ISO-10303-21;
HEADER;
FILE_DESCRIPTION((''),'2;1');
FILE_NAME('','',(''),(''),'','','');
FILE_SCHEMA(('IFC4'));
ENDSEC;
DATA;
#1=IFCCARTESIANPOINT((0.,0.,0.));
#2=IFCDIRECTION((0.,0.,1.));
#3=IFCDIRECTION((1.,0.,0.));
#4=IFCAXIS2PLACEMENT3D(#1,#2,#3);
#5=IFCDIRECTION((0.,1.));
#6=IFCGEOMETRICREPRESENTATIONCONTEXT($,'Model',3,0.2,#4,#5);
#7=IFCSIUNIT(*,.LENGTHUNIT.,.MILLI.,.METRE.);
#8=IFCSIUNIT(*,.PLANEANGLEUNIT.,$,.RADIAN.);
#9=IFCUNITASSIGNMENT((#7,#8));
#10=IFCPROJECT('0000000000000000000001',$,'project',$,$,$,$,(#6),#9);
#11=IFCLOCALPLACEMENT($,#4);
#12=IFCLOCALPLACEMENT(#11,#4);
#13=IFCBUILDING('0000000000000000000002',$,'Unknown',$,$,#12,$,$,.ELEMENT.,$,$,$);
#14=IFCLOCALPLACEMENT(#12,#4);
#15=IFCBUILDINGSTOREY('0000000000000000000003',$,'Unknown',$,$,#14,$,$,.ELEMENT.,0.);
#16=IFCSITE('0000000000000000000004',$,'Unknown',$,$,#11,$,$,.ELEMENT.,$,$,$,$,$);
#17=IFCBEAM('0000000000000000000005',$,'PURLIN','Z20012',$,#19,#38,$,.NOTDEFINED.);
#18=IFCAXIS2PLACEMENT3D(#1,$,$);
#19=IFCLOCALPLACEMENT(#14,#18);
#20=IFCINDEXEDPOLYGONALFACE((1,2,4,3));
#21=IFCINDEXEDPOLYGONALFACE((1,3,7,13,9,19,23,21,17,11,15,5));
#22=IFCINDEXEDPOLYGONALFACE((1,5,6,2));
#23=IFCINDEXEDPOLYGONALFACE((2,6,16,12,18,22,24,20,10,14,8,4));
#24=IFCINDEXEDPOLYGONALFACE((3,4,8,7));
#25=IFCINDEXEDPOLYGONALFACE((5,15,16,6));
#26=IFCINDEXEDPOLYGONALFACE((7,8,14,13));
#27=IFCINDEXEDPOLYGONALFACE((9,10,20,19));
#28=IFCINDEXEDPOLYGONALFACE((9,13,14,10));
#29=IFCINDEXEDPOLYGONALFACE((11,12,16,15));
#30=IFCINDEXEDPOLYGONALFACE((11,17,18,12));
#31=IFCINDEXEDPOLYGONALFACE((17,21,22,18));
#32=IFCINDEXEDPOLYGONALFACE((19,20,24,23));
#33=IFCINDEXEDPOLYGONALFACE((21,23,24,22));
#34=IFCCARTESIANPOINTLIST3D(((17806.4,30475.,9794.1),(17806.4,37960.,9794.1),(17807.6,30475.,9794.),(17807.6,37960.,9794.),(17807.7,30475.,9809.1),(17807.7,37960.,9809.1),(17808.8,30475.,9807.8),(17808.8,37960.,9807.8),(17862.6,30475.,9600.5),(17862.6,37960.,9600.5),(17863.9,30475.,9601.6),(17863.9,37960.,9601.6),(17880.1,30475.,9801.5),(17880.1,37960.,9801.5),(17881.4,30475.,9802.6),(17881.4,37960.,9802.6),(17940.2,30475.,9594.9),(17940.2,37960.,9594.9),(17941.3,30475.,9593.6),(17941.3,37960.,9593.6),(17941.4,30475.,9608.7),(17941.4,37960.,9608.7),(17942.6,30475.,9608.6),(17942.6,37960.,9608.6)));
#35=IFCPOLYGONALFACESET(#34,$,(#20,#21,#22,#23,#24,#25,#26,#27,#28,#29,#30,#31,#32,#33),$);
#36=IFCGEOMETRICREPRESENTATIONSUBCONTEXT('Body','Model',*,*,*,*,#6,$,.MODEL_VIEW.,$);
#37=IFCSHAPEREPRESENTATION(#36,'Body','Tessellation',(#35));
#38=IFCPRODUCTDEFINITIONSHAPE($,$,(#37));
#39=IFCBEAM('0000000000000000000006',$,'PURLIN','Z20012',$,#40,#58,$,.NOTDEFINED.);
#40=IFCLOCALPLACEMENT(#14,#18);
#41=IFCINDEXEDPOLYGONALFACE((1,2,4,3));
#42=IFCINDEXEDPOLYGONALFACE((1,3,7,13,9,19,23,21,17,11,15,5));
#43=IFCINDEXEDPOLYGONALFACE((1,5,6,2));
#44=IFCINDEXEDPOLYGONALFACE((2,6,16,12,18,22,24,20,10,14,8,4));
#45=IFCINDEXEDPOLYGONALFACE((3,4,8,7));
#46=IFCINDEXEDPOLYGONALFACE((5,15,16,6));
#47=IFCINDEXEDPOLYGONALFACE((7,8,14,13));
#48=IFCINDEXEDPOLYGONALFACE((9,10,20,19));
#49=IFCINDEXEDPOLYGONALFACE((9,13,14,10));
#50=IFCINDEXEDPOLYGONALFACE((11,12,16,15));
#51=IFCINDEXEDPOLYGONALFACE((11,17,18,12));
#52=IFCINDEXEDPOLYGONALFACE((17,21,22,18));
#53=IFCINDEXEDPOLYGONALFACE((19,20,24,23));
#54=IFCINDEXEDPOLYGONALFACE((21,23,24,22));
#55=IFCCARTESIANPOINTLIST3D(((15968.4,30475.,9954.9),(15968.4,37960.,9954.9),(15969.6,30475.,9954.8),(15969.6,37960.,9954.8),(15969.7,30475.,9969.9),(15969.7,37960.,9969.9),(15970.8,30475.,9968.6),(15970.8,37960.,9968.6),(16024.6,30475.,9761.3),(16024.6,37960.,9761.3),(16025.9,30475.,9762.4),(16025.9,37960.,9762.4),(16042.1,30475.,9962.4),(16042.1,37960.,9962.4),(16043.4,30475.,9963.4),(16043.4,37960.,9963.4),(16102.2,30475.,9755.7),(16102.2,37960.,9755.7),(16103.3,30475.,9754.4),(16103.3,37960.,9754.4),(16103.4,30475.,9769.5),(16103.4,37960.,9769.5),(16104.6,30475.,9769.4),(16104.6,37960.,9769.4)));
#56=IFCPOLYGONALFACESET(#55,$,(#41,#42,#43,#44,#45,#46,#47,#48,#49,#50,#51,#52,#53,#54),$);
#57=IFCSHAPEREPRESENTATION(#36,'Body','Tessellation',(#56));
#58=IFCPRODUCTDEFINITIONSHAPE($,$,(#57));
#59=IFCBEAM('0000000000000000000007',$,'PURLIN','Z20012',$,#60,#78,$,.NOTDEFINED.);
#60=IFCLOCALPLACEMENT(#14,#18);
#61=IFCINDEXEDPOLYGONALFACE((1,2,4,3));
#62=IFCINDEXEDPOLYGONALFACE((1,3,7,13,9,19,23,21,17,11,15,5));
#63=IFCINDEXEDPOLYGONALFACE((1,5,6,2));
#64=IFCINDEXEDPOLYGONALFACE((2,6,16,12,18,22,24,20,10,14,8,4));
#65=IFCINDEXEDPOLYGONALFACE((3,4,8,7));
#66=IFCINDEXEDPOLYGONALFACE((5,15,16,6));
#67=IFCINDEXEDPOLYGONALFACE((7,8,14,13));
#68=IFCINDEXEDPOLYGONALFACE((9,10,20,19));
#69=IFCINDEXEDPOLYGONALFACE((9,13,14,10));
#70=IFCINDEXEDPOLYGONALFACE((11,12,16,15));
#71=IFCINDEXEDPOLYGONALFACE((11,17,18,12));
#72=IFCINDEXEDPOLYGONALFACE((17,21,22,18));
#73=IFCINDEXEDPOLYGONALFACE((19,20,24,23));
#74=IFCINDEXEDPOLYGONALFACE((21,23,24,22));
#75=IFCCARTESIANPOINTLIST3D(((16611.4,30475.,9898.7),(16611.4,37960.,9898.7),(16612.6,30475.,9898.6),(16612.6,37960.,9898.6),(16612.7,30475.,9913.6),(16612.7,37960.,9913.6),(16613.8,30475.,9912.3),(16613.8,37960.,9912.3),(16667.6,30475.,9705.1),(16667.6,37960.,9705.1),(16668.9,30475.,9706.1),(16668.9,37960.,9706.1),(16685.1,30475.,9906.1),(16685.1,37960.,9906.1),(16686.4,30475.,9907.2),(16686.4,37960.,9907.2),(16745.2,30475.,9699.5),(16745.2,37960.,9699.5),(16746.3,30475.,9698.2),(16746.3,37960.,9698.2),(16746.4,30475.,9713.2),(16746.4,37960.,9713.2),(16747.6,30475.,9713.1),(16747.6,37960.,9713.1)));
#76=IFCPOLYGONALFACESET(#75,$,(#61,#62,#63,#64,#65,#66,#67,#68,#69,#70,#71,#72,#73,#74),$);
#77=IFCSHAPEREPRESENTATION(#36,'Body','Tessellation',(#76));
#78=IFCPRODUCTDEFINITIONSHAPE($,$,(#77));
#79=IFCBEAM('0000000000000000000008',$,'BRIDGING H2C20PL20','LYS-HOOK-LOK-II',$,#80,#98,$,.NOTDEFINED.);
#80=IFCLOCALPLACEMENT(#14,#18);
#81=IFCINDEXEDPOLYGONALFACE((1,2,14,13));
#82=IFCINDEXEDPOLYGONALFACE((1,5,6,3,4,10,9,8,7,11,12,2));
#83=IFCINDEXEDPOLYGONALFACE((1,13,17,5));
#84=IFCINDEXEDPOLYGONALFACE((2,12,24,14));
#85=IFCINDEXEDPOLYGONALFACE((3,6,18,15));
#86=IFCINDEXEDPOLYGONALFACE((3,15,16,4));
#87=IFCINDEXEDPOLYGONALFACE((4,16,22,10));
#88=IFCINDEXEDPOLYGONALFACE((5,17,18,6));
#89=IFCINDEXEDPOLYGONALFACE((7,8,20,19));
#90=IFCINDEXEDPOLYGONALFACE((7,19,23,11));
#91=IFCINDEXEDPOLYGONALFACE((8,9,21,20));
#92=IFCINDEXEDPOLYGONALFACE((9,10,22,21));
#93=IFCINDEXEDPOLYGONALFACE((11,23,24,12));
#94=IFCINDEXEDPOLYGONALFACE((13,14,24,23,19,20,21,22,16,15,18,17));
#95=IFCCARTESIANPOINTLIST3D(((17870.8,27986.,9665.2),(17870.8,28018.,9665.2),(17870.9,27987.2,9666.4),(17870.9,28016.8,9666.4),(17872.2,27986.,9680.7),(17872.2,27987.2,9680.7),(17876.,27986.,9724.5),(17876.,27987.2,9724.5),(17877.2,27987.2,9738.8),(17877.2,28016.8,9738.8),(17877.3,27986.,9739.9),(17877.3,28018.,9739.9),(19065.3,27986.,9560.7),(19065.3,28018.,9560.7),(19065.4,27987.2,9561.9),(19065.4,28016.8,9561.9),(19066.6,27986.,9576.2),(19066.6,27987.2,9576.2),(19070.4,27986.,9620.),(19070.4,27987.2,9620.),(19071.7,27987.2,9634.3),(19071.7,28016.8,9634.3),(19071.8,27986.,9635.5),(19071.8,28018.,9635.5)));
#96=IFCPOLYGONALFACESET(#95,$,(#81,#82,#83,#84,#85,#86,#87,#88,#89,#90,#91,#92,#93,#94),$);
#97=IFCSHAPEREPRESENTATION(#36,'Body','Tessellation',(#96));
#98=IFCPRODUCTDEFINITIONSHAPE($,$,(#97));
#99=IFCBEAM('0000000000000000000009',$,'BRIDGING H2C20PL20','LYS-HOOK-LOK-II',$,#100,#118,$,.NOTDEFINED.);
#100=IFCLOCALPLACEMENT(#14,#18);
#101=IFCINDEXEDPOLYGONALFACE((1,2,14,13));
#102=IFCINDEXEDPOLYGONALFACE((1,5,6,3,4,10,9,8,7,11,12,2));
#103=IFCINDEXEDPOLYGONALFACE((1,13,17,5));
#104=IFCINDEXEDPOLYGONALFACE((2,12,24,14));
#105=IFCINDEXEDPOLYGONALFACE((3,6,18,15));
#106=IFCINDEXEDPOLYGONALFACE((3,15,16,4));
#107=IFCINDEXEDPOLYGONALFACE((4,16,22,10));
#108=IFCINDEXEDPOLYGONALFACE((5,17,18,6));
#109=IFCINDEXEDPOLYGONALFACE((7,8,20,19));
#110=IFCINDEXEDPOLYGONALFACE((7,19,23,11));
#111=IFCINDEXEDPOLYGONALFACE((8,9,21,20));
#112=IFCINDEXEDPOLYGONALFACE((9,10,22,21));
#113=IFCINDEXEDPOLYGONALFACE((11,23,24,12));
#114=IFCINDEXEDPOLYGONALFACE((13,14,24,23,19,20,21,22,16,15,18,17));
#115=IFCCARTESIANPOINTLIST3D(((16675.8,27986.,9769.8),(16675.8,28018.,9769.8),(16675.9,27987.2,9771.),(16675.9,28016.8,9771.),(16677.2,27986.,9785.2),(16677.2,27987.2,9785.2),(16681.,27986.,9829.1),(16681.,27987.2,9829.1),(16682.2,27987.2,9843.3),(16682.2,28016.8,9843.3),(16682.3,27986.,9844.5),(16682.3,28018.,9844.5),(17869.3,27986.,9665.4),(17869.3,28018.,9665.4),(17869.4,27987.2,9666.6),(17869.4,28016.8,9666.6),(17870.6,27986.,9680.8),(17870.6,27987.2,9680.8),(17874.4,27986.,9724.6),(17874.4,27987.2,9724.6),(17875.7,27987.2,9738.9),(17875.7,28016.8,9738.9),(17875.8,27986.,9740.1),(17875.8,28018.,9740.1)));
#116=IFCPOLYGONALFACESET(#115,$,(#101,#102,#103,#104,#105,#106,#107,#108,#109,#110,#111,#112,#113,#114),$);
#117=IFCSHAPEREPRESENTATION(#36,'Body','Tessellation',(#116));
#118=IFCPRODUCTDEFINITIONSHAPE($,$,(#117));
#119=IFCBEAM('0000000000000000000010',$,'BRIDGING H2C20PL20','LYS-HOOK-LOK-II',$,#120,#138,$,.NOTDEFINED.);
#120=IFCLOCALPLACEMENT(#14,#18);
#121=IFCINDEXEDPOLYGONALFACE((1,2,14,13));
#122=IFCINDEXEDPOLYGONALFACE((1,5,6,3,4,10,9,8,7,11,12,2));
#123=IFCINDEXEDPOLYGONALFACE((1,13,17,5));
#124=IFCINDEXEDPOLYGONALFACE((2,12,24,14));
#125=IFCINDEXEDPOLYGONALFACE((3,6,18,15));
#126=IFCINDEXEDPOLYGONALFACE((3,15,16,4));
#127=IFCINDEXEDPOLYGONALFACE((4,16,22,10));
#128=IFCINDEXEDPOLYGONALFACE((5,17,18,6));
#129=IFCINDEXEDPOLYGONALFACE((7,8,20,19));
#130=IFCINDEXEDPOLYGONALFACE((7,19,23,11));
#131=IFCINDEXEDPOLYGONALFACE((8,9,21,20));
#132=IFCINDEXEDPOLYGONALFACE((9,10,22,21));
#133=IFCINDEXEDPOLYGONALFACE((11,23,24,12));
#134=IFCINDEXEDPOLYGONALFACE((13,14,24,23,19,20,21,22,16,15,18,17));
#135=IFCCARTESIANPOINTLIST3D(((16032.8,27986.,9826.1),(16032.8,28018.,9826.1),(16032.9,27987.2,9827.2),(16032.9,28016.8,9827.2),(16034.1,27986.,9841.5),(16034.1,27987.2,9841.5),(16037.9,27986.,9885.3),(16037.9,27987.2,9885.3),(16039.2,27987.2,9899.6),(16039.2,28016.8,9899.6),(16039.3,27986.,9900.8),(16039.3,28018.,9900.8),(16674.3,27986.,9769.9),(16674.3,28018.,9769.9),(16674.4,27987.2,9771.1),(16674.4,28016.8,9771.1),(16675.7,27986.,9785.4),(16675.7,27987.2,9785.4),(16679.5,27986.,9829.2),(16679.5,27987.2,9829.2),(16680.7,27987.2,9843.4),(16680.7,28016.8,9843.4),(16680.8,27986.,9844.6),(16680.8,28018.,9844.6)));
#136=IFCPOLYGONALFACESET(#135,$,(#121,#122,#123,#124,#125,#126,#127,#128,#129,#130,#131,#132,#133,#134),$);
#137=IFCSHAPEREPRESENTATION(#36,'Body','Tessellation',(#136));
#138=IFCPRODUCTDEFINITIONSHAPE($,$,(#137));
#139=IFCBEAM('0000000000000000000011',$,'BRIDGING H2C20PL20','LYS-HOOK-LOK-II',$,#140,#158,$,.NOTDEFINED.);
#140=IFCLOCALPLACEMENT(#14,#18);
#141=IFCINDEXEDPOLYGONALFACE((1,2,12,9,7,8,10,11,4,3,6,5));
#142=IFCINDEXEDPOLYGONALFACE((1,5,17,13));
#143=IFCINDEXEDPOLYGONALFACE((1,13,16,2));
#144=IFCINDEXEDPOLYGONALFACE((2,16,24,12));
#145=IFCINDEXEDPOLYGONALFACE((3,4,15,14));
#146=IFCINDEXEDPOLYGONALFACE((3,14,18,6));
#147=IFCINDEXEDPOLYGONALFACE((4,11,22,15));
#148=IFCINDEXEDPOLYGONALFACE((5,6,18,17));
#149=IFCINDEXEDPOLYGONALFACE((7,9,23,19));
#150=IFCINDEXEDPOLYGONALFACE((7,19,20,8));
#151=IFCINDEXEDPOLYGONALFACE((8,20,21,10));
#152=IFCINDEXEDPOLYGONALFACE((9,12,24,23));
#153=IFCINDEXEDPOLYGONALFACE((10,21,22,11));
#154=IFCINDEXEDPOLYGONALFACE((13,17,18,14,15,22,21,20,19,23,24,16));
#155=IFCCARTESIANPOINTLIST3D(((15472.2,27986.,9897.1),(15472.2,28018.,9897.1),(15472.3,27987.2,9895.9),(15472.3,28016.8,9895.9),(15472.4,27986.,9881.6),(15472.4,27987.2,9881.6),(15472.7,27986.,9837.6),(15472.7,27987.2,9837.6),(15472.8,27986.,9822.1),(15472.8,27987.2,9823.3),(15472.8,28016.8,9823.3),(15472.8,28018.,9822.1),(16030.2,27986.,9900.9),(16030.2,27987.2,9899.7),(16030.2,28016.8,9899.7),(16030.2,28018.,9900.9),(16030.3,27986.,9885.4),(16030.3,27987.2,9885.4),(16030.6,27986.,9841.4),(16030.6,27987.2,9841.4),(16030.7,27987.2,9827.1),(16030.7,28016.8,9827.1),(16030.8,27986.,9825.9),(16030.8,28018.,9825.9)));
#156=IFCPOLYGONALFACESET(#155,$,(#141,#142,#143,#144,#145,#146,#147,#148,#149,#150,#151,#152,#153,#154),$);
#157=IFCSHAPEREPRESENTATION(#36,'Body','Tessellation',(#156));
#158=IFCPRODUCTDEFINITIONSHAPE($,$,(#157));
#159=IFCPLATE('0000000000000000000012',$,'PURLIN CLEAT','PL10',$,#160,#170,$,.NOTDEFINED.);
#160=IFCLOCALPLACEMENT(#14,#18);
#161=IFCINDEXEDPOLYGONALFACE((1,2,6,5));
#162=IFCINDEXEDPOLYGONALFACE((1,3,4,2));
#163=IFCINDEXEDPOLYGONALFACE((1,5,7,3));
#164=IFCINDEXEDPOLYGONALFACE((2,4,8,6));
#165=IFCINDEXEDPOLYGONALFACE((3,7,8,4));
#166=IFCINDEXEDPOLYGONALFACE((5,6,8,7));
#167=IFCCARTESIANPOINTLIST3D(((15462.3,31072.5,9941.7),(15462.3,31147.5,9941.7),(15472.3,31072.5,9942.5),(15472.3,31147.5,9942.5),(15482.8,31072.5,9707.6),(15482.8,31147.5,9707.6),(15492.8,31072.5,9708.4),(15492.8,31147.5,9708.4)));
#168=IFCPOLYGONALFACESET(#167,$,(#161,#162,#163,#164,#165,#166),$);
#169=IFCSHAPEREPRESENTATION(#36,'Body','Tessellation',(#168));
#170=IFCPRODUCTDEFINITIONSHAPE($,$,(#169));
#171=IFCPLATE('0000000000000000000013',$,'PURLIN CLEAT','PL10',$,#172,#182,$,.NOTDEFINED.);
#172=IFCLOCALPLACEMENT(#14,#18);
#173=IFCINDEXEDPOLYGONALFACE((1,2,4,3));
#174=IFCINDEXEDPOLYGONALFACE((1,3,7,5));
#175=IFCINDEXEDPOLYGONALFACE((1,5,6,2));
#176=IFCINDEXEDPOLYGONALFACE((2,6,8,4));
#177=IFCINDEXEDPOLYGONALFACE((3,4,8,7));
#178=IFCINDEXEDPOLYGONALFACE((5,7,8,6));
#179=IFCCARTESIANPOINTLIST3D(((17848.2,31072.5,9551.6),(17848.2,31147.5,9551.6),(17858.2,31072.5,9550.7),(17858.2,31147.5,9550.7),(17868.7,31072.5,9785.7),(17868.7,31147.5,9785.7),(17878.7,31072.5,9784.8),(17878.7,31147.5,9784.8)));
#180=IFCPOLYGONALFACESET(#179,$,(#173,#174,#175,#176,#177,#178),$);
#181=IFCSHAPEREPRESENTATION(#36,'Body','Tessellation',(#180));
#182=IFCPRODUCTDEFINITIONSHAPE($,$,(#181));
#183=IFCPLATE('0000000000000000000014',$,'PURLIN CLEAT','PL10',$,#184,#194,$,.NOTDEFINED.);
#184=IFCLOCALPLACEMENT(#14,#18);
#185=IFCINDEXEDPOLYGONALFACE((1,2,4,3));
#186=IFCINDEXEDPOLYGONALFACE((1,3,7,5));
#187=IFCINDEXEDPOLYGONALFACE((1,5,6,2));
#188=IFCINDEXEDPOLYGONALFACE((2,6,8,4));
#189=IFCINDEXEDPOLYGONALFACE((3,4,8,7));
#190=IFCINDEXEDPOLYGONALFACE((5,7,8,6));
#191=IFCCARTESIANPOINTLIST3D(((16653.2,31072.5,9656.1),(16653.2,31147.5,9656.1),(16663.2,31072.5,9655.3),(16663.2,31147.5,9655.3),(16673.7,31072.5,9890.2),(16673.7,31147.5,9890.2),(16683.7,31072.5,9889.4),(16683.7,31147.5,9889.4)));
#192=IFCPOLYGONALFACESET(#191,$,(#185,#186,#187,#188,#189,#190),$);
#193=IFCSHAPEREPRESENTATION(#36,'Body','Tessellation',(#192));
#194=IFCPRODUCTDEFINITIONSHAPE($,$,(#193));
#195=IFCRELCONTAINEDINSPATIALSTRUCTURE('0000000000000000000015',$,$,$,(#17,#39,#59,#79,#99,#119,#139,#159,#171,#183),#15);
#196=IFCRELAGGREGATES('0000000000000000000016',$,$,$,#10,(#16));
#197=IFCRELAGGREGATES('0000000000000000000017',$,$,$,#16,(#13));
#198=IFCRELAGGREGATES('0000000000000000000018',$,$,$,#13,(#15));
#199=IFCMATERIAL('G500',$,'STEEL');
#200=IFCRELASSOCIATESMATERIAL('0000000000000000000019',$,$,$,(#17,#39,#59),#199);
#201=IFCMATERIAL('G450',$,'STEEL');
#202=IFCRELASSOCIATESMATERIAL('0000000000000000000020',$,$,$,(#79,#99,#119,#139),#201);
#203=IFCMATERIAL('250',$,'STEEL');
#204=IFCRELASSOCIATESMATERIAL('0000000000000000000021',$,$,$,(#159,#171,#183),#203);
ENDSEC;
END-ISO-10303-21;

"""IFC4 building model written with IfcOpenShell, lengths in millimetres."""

from ifc_helpers import new_model, si_unit, direction, frame, origin_with_axes, place, context, subcontext, project, spatial, line, indexed_curve, outline, extrude, material, element, save


model = new_model("IFC4")

# Units and contexts
model_context = context("Model", 3, precision=0.2, world=origin_with_axes(), true_north=direction((0.0, 1.0)))
body_context = subcontext(model_context, "Body", "Model", "MODEL_VIEW")
ifc_project = project(units=[si_unit("LENGTHUNIT", "METRE", prefix="MILLI"), si_unit("PLANEANGLEUNIT", "RADIAN")], contexts=[model_context])

# Site, building, storey
site_placement = place(None, origin_with_axes())
site = spatial("IfcSite", under=ifc_project, at=site_placement, Name="Unknown", CompositionType="ELEMENT")
building_placement = place(site_placement, origin_with_axes())
building = spatial("IfcBuilding", under=site, at=building_placement, Name="Unknown", CompositionType="ELEMENT")
storey_placement = place(building_placement, origin_with_axes())
storey = spatial("IfcBuildingStorey", under=building, at=storey_placement, Name="Unknown", CompositionType="ELEMENT", Elevation=0.0)

# Beams
ifc_material_1 = material(Name="G500", Category="STEEL")
for number, where, z_axis, x_axis, name in (
    (1, (17872.0, 30475.0, 9701.6), (-0.996195, 0.0, 0.087156), (0.0, 1.0, 0.0), "PURLIN"),
    (2, (16034.0, 30475.0, 9862.4), (-0.996195, 0.0, 0.087156), (0.0, 1.0, 0.0), "PURLIN"),
    (3, (16677.0, 30475.0, 9806.1), (-0.996195, 0.0, 0.087156), (0.0, 1.0, 0.0), "PURLIN"),
):
    element("IfcBeam", number, at=place(storey_placement, frame(where, z_axis=z_axis, x_axis=x_axis)), inside=storey, material=ifc_material_1, Name=name, Description="Z20012", PredefinedType="NOTDEFINED", context=body_context, shape_type="SolidModel", body=[
        extrude(outline(indexed_curve([(73.4, -101.5), (73.4, -86.5), (72.2, -86.5), (72.2, -100.3), (0.6, -100.3), (0.6, 101.5), (-78.4, 101.5), (-78.4, 86.5), (-77.2, 86.5), (-77.2, 100.3), (-0.6, 100.3), (-0.6, -101.5)], segments=[line(1, 2, 3, 4, 5, 6, 7, 8, 9, 10, 11, 12, 1)])), frame((0.0, 0.0, 0.0), z_axis=(-1.0, 0.0, 0.0), x_axis=(0.0, 0.0, 1.0)), (0.0, 0.0, -1.0), 7485.0),
    ])
ifc_material_2 = material(Name="G450", Category="STEEL")
beam_1_placement = place(storey_placement, frame((17874.1, 28002.0, 9702.6), z_axis=(0.0, -1.0, 0.0), x_axis=(0.996195, 0.0, -0.08715)))
element("IfcBeam", 4, at=beam_1_placement, inside=storey, material=ifc_material_2, Name="BRIDGING H2C20PL20", Description="LYS-HOOK-LOK-II", PredefinedType="NOTDEFINED", context=body_context, shape_type="SolidModel", body=[
    extrude(outline(indexed_curve([(16.0, -37.5), (16.0, -22.0), (14.8, -22.0), (14.8, -36.3), (-14.8, -36.3), (-14.8, 36.3), (14.8, 36.3), (14.8, 22.0), (16.0, 22.0), (16.0, 37.5), (-16.0, 37.5), (-16.0, -37.5)], segments=[line(1, 2, 3, 4, 5, 6, 7, 8, 9, 10, 11, 12, 1)])), frame((0.0, 0.0, 0.0), z_axis=(-1.0, 0.0, 0.0), x_axis=(0.0, 0.0, 1.0)), (0.0, 0.0, -1.0), 1199.0),
])
beam_2_placement = place(storey_placement, frame((16679.1, 28002.0, 9807.1), z_axis=(0.0, -1.0, 0.0), x_axis=(0.996195, 0.0, -0.087157)))
element("IfcBeam", 5, at=beam_2_placement, inside=storey, material=ifc_material_2, Name="BRIDGING H2C20PL20", Description="LYS-HOOK-LOK-II", PredefinedType="NOTDEFINED", context=body_context, shape_type="SolidModel", body=[
    extrude(outline(indexed_curve([(16.0, -37.5), (16.0, -22.0), (14.8, -22.0), (14.8, -36.3), (-14.8, -36.3), (-14.8, 36.3), (14.8, 36.3), (14.8, 22.0), (16.0, 22.0), (16.0, 37.5), (-16.0, 37.5), (-16.0, -37.5)], segments=[line(1, 2, 3, 4, 5, 6, 7, 8, 9, 10, 11, 12, 1)])), frame((0.0, 0.0, 0.0), z_axis=(-1.0, 0.0, 0.0), x_axis=(0.0, 0.0, 1.0)), (0.0, 0.0, -1.0), 1198.0),
])
beam_3_placement = place(storey_placement, frame((16036.0, 28002.0, 9863.4), z_axis=(0.0, -1.0, 0.0), x_axis=(0.996194, 0.0, -0.087163)))
element("IfcBeam", 6, at=beam_3_placement, inside=storey, material=ifc_material_2, Name="BRIDGING H2C20PL20", Description="LYS-HOOK-LOK-II", PredefinedType="NOTDEFINED", context=body_context, shape_type="SolidModel", body=[
    extrude(outline(indexed_curve([(16.0, -37.5), (16.0, -22.0), (14.8, -22.0), (14.8, -36.3), (-14.8, -36.3), (-14.8, 36.3), (14.8, 36.3), (14.8, 22.0), (16.0, 22.0), (16.0, 37.5), (-16.0, 37.5), (-16.0, -37.5)], segments=[line(1, 2, 3, 4, 5, 6, 7, 8, 9, 10, 11, 12, 1)])), frame((0.0, 0.0, 0.0), z_axis=(-1.0, 0.0, 0.0), x_axis=(0.0, 0.0, 1.0)), (0.0, 0.0, -1.0), 644.0),
])
beam_4_placement = place(storey_placement, frame((15472.5, 28002.0, 9859.6), z_axis=(0.0, -1.0, 0.0), x_axis=(0.999976, 0.0, 0.006941)))
element("IfcBeam", 7, at=beam_4_placement, inside=storey, material=ifc_material_2, Name="BRIDGING H2C20PL20", Description="LYS-HOOK-LOK-II", PredefinedType="NOTDEFINED", context=body_context, shape_type="SolidModel", body=[
    extrude(outline(indexed_curve([(16.0, -37.5), (16.0, -22.0), (14.8, -22.0), (14.8, -36.3), (-14.8, -36.3), (-14.8, 36.3), (14.8, 36.3), (14.8, 22.0), (16.0, 22.0), (16.0, 37.5), (-16.0, 37.5), (-16.0, -37.5)], segments=[line(1, 2, 3, 4, 5, 6, 7, 8, 9, 10, 11, 12, 1)])), frame((0.0, 0.0, 0.0), z_axis=(-1.0, 0.0, 0.0), x_axis=(0.0, 0.0, 1.0)), (0.0, 0.0, -1.0), 558.0),
])

# Plates
ifc_material_3 = material(Name="250", Category="STEEL")
for number, where, z_axis, x_axis, name in (
    (8, (15487.8, 31072.5, 9708.0), (0.996195, 0.0, 0.087156), (0.0, 1.0, 0.0), "PURLIN CLEAT"),
    (9, (17853.2, 31072.5, 9551.1), (0.996195, 0.0, -0.087156), (0.0, 1.0, 0.0), "PURLIN CLEAT"),
    (10, (16658.2, 31072.5, 9655.7), (0.996195, 0.0, -0.087156), (0.0, 1.0, 0.0), "PURLIN CLEAT"),
):
    element("IfcPlate", number, at=place(storey_placement, frame(where, z_axis=z_axis, x_axis=x_axis)), inside=storey, material=ifc_material_3, Name=name, Description="PL10", PredefinedType="NOTDEFINED", context=body_context, shape_type="SolidModel", body=[
        extrude(outline(indexed_curve([(0.0, 0.0), (75.0, 0.0), (75.0, 235.0), (0.0, 235.0)], segments=[line(1, 2, 3, 4, 1)])), frame((0.0, 0.0, 5.0), z_axis=(0.0, 0.0, 1.0), x_axis=(1.0, 0.0, 0.0)), (0.0, 0.0, -1.0), 10.0),
    ])

save(model, "model.ifc")
